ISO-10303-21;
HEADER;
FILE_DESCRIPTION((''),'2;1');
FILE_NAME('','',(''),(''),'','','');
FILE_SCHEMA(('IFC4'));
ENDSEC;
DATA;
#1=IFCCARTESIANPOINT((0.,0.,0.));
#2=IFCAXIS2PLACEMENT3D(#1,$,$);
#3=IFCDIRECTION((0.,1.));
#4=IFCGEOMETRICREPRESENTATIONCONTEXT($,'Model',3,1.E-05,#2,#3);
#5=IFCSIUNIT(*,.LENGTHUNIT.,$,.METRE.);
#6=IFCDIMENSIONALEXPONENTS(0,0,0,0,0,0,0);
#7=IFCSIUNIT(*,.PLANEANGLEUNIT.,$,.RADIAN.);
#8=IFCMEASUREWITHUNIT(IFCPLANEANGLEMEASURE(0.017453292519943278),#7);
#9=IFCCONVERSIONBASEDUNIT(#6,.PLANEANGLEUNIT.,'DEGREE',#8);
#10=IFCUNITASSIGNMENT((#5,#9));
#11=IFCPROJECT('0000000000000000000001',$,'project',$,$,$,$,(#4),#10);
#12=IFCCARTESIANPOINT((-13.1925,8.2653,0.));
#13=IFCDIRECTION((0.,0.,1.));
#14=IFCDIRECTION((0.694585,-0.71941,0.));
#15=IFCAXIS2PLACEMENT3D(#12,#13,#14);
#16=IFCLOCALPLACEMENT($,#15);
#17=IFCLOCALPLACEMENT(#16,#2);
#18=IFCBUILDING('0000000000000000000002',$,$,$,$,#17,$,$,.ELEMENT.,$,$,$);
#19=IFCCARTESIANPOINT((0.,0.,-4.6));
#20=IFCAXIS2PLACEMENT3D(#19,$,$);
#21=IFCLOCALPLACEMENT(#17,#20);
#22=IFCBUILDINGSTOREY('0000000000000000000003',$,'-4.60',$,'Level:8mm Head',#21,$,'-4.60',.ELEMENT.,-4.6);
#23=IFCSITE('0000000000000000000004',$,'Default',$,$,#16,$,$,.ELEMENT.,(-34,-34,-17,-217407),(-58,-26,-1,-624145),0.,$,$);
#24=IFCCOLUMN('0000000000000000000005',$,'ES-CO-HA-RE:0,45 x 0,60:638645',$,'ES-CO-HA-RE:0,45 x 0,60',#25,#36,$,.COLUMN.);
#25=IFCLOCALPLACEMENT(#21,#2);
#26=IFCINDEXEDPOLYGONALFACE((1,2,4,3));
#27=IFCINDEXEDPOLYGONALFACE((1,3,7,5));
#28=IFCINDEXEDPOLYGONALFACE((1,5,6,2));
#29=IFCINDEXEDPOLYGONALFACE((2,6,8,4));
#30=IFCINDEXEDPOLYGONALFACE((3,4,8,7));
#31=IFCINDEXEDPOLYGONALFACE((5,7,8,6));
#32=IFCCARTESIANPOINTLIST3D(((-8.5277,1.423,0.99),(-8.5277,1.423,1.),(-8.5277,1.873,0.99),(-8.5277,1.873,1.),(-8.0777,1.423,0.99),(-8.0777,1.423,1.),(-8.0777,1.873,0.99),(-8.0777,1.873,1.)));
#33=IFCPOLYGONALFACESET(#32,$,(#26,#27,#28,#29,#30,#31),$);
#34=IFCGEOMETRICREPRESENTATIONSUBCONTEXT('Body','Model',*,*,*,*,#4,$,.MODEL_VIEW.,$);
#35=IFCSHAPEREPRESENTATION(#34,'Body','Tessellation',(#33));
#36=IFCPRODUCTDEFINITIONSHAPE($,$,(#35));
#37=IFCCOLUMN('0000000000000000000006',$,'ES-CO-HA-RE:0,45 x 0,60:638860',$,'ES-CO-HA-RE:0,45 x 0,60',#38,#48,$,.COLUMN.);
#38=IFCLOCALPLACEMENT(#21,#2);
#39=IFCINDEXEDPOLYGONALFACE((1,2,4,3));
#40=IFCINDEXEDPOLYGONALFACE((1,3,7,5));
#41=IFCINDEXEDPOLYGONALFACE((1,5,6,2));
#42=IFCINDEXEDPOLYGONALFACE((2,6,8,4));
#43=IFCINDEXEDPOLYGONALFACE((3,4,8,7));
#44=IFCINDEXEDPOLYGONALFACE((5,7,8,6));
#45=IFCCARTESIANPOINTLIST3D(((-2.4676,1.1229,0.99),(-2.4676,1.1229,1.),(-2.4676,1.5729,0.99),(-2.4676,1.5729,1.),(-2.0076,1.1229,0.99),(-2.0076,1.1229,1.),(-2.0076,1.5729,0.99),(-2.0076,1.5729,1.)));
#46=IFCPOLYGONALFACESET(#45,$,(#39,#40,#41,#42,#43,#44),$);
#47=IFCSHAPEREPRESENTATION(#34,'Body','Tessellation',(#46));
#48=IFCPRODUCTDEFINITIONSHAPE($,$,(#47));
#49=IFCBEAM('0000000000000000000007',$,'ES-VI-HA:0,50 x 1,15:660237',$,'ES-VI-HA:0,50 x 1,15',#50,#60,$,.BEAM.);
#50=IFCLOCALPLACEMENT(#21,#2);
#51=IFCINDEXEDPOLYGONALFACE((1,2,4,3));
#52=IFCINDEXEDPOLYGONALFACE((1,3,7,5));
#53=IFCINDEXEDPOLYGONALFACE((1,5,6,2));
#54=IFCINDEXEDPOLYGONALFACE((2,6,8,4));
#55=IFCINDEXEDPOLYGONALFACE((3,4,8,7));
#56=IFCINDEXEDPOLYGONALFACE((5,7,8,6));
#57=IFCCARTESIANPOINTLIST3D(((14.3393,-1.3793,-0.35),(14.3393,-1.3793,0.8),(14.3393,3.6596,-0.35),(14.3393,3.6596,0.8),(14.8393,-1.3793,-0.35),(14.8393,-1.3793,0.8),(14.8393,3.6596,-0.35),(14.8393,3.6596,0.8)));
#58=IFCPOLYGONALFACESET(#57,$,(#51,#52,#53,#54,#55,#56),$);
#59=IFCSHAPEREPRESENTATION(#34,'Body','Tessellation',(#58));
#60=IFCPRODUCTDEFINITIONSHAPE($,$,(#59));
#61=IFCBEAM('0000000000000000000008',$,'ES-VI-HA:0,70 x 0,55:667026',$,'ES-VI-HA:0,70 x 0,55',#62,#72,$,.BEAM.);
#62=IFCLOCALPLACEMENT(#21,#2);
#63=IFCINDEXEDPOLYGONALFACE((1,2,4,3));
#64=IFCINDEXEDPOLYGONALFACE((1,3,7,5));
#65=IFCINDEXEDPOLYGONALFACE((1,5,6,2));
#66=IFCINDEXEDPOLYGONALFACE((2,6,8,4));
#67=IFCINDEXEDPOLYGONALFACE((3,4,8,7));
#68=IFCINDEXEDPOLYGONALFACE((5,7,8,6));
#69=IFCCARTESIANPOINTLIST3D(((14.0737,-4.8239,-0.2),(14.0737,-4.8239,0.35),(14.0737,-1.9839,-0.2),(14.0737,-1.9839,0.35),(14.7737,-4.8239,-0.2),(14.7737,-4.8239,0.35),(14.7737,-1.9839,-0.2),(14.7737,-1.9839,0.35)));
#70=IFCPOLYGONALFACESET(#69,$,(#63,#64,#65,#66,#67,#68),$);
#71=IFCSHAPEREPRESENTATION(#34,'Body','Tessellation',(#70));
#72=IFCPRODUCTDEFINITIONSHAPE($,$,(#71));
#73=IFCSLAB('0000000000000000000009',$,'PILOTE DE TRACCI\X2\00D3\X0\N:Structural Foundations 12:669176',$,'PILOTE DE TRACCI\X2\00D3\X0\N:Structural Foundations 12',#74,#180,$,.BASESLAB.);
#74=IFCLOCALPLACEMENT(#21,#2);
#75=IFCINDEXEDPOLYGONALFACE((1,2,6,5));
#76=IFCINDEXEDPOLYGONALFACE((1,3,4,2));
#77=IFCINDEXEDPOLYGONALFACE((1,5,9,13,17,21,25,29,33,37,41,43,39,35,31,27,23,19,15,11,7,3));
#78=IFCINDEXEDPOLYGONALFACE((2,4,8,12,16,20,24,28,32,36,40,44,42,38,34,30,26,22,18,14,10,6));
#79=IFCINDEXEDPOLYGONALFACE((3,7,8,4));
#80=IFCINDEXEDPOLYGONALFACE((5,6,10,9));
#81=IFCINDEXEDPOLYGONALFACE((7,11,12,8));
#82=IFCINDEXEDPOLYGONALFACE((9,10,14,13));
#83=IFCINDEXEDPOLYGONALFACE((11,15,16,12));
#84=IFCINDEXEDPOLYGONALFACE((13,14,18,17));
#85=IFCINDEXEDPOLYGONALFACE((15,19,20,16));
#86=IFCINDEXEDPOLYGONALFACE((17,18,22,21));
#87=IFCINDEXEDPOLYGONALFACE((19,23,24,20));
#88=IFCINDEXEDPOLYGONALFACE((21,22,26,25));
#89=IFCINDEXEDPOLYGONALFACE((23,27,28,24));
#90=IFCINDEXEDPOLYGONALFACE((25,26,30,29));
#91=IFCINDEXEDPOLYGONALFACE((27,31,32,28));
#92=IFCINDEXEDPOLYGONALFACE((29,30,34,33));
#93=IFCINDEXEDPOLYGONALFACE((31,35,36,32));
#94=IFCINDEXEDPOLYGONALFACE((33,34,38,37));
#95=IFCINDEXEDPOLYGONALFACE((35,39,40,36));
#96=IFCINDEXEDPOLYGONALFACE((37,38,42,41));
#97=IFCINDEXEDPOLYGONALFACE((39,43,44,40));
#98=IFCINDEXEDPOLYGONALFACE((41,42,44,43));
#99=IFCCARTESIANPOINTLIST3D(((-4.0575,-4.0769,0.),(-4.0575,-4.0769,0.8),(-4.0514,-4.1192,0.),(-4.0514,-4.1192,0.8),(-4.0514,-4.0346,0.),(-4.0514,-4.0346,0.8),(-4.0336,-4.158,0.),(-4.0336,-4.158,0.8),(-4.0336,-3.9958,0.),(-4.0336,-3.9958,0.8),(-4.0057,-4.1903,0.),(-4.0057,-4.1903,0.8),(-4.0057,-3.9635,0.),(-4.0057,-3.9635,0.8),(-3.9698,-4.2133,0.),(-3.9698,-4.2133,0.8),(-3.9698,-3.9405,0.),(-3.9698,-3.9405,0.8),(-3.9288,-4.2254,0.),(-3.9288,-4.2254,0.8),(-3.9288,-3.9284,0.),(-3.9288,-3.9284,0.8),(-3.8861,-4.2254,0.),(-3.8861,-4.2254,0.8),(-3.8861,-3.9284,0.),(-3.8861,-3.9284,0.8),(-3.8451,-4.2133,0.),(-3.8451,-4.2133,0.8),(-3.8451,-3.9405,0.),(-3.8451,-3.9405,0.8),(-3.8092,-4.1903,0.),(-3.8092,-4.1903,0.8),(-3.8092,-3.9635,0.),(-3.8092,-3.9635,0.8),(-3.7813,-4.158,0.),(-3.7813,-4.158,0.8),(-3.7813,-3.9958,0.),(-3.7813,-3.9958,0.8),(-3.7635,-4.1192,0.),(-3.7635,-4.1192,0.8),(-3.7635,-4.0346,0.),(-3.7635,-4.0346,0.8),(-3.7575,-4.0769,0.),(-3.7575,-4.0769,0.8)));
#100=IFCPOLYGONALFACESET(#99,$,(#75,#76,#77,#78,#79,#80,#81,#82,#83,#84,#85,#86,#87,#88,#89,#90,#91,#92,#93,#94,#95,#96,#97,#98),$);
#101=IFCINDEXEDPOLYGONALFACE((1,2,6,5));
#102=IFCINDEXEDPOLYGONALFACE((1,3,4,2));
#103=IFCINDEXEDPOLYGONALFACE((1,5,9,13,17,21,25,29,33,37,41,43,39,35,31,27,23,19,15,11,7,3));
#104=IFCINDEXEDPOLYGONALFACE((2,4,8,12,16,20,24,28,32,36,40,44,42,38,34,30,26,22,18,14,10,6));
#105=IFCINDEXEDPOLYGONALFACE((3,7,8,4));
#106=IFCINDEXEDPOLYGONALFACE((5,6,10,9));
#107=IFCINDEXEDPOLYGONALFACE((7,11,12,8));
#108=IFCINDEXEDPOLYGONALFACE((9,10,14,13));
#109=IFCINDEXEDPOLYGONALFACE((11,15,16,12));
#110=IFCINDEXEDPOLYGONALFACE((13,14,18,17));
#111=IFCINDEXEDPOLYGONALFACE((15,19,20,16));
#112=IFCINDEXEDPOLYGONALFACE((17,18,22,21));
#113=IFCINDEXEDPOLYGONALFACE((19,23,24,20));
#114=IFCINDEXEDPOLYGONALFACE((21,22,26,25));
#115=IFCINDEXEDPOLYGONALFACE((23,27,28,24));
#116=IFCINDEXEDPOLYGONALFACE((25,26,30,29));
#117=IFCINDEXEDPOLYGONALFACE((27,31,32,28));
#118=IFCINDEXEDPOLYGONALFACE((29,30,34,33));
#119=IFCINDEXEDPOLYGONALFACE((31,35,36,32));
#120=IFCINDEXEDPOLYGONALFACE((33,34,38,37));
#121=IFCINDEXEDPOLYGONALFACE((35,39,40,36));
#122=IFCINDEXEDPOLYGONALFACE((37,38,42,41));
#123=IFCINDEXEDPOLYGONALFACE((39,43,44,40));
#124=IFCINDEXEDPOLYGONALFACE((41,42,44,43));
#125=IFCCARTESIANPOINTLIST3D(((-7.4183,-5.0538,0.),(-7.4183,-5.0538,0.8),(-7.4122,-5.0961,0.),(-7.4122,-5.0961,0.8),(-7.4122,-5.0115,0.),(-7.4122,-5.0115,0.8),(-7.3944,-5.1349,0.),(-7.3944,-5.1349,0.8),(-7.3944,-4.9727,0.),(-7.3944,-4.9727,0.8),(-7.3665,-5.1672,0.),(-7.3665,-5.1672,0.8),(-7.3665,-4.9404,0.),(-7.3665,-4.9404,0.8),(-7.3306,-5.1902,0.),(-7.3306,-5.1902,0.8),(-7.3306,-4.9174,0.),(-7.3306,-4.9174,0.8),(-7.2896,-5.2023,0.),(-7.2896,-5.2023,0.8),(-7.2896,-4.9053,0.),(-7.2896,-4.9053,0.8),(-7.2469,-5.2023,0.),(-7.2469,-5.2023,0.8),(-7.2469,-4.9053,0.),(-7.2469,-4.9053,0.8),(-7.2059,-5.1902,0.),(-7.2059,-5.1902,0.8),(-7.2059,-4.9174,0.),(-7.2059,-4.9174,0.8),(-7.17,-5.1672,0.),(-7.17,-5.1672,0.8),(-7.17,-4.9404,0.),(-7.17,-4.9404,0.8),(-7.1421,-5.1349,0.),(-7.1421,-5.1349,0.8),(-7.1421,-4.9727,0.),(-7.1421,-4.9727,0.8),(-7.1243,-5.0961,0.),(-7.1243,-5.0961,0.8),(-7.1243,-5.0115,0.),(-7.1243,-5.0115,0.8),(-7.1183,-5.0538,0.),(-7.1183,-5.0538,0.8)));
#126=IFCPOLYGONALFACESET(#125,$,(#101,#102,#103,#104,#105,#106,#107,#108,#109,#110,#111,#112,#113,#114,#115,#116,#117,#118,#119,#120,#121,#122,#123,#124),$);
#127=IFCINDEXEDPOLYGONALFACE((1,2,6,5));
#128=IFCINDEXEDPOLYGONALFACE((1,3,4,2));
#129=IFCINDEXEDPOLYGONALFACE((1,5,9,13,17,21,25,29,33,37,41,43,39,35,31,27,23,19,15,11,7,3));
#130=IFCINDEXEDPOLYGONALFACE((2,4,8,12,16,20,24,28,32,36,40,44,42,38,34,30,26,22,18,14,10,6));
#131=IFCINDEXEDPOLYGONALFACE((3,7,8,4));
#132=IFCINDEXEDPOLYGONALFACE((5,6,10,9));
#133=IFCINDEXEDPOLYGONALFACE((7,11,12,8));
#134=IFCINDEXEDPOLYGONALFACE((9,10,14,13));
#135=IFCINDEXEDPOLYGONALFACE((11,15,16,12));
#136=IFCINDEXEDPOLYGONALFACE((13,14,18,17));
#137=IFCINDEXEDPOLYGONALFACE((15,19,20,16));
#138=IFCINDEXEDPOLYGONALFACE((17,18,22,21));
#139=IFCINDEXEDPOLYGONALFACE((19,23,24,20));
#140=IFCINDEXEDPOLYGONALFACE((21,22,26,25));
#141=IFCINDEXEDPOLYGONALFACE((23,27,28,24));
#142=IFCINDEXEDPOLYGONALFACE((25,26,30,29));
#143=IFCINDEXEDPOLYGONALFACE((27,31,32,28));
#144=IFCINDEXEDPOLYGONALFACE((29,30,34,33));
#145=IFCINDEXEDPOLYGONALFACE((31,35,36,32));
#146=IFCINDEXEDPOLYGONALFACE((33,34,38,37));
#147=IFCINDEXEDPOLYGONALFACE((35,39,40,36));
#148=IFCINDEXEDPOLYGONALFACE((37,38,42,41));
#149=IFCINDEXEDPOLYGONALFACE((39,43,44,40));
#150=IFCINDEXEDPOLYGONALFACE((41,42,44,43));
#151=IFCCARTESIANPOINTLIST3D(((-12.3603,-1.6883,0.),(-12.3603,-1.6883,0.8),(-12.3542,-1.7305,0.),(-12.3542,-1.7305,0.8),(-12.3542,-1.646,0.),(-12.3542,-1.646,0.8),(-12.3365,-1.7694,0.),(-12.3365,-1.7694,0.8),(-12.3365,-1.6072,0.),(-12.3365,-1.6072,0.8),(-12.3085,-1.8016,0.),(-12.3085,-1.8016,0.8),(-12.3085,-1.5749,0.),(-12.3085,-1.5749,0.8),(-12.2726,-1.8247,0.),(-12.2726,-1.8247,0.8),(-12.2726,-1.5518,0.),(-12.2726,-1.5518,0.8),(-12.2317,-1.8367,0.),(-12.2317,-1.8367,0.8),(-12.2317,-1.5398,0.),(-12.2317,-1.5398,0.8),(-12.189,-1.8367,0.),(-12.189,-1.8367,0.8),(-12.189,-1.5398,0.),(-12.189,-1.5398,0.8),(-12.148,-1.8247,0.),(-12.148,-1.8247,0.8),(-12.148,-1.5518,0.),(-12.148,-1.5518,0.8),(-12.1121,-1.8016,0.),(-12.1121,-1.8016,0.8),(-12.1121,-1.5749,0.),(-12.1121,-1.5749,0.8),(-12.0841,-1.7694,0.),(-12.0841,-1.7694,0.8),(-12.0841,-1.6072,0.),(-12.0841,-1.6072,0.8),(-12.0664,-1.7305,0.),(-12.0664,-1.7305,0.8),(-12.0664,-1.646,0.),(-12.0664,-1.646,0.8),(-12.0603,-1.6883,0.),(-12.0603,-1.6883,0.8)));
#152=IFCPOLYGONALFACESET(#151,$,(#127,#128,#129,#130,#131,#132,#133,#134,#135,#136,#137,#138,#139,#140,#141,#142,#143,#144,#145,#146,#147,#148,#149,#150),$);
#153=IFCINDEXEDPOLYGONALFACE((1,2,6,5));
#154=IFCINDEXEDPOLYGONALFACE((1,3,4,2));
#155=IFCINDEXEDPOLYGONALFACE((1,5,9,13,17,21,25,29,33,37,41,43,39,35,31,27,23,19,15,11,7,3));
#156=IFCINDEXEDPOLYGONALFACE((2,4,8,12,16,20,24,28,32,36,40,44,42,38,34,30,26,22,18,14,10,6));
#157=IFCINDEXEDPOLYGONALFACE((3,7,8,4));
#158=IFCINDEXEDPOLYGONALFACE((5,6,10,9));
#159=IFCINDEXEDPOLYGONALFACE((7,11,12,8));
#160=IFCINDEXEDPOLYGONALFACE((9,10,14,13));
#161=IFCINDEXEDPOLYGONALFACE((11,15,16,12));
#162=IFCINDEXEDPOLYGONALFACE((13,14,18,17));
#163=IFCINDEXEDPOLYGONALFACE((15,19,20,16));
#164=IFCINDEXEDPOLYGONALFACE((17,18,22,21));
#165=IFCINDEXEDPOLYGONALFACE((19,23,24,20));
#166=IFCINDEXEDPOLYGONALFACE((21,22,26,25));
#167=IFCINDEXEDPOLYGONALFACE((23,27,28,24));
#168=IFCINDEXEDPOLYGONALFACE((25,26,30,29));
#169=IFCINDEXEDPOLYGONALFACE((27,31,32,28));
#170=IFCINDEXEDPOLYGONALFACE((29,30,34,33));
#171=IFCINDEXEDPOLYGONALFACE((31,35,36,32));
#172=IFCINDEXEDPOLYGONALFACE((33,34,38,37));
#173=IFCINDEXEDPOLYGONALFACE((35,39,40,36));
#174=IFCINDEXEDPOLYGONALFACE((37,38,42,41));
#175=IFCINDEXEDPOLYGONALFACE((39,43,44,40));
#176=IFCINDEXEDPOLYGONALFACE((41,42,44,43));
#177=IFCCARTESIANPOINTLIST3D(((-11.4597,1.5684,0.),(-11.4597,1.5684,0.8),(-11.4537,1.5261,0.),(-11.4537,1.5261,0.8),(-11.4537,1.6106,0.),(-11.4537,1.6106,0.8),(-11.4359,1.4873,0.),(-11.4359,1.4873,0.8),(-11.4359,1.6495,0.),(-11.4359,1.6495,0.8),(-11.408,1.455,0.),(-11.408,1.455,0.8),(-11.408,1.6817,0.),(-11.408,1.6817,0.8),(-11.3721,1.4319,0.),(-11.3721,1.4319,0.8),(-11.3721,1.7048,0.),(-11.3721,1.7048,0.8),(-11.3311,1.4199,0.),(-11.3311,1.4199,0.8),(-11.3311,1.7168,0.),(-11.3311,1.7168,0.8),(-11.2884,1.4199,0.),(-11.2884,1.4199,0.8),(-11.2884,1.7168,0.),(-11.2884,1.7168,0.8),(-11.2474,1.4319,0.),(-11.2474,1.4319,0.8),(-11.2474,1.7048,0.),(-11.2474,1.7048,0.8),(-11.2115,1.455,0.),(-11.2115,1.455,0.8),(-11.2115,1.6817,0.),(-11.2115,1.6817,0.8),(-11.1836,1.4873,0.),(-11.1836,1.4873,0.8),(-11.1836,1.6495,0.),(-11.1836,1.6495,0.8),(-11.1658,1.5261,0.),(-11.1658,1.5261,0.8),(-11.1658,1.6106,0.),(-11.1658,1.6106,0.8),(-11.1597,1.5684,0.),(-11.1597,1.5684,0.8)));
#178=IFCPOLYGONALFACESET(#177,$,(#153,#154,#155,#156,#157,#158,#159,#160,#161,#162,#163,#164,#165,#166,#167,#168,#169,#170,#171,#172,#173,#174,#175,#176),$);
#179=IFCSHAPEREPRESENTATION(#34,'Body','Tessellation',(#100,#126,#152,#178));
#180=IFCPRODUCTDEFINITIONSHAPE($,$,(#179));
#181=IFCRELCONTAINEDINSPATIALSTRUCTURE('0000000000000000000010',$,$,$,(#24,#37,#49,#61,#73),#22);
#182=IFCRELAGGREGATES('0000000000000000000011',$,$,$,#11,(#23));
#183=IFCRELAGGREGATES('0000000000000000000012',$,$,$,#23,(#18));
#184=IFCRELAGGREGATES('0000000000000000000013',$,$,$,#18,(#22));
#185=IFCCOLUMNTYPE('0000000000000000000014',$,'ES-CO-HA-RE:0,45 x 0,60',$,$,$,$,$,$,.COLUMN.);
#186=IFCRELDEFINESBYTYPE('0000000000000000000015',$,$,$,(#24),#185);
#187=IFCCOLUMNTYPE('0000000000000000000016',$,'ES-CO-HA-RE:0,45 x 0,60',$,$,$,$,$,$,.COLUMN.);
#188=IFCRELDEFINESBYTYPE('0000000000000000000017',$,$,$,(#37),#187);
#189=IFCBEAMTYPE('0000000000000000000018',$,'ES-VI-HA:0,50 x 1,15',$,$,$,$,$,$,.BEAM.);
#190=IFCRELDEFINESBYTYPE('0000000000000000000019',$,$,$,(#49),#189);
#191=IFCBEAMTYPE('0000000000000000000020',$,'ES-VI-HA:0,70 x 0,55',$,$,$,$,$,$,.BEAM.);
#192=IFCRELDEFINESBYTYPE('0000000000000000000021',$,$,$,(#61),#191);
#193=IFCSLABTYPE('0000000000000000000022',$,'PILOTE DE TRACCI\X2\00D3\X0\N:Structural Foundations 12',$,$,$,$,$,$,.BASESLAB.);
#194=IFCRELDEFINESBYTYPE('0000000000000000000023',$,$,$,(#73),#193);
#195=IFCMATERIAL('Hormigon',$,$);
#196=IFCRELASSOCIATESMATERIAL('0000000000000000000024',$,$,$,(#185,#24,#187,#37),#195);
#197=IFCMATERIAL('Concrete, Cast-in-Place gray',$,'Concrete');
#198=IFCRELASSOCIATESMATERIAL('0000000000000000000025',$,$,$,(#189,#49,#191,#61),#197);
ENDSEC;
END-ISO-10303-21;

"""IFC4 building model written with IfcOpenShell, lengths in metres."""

from ifc_helpers import new_model, entity, si_unit, converted_unit, direction, frame, origin, place, context, subcontext, project, spatial, arc, indexed_curve, outline, extrude, source, transform, mapped, material, type_object, type_shapes, element, save


model = new_model("IFC4")

# Units and contexts
model_context = context("Model", 3, precision=1e-05, world=origin(), true_north=direction((0.0, 1.0)))
body_context = subcontext(model_context, "Body", "Model", "MODEL_VIEW")
ifc_project = project(units=[si_unit("LENGTHUNIT", "METRE"), converted_unit("PLANEANGLEUNIT", "DEGREE", entity("IfcPlaneAngleMeasure", 0.017453292519943278), si_unit("PLANEANGLEUNIT", "RADIAN"), dimensions=[0, 0, 0, 0, 0, 0, 0])], contexts=[model_context])

# Site, building, storey
site_placement = place(None, frame((-13.1925, 8.2653, 0.0), z_axis=(0.0, 0.0, 1.0), x_axis=(0.694585, -0.71941, 0.0)))
site = spatial("IfcSite", under=ifc_project, at=site_placement, Name="Default", CompositionType="ELEMENT", RefLatitude=(-34, -34, -17, -217407), RefLongitude=(-58, -26, -1, -624145), RefElevation=0.0)
building_placement = place(site_placement, origin())
building = spatial("IfcBuilding", under=site, at=building_placement, CompositionType="ELEMENT")
storey_placement = place(building_placement, frame((0.0, 0.0, -4.6)))
storey = spatial("IfcBuildingStorey", under=building, at=storey_placement, Name="-4.60", ObjectType="Level:8mm Head", LongName="-4.60", CompositionType="ELEMENT", Elevation=-4.6)

# Columns
ifc_material_1 = material(Name="Hormigon")
column_type_1 = type_object("IfcColumnType", Name="ES-CO-HA-RE:0,45 x 0,60", PredefinedType="COLUMN", material=ifc_material_1)
shared_shape_1 = source(origin(), body_context, "Body", "SweptSolid", [
    extrude(outline(indexed_curve([(-0.225, -0.225), (0.225, -0.225), (0.225, 0.225), (-0.225, 0.225), (-0.225, -0.225)], self_intersect=False)), frame((0.0, 0.0, -3.61), z_axis=(0.0, 0.0, 1.0), x_axis=(-1.0, 0.0, 0.0)), (0.0, 0.0, 1.0), 0.01),
])
type_shapes(column_type_1, [shared_shape_1])
column_1_placement = place(storey_placement, frame((-8.3027, 1.648, 4.6)))
element("IfcColumn", 1, at=column_1_placement, inside=storey, type_object=column_type_1, material=ifc_material_1, Name="ES-CO-HA-RE:0,45 x 0,60:638645", ObjectType="ES-CO-HA-RE:0,45 x 0,60", PredefinedType="COLUMN", context=body_context, shape_type="MappedRepresentation", body=[
    mapped(shared_shape_1, transform((0.0, 0.0, 0.0), scale=1.0)),
])
column_type_2 = type_object("IfcColumnType", Name="ES-CO-HA-RE:0,45 x 0,60", PredefinedType="COLUMN", material=ifc_material_1)
shared_shape_2 = source(origin(), body_context, "Body", "SweptSolid", [
    extrude(outline(indexed_curve([(-0.23, -0.225), (0.23, -0.225), (0.23, 0.225), (-0.23, 0.225), (-0.23, -0.225)], self_intersect=False)), frame((0.0, 0.0, -3.61), z_axis=(0.0, 0.0, 1.0), x_axis=(-1.0, 0.0, 0.0)), (0.0, 0.0, 1.0), 0.01),
])
type_shapes(column_type_2, [shared_shape_2])
column_2_placement = place(storey_placement, frame((-2.2376, 1.3479, 4.6)))
element("IfcColumn", 2, at=column_2_placement, inside=storey, type_object=column_type_2, material=ifc_material_1, Name="ES-CO-HA-RE:0,45 x 0,60:638860", ObjectType="ES-CO-HA-RE:0,45 x 0,60", PredefinedType="COLUMN", context=body_context, shape_type="MappedRepresentation", body=[
    mapped(shared_shape_2, transform((0.0, 0.0, 0.0), scale=1.0)),
])

# Beams
ifc_material_2 = material(Name="Concrete, Cast-in-Place gray", Category="Concrete")
beam_type_1 = type_object("IfcBeamType", Name="ES-VI-HA:0,50 x 1,15", PredefinedType="BEAM", material=ifc_material_2)
shared_shape_3 = source(origin(), body_context, "Body", "SweptSolid", [
    extrude(outline(indexed_curve([(-0.25, -0.575), (0.25, -0.575), (0.25, 0.575), (-0.25, 0.575), (-0.25, -0.575)], self_intersect=False)), frame((14.5893, -1.3793, -4.375), z_axis=(0.0, 1.0, 0.0), x_axis=(-1.0, 0.0, 0.0)), (0.0, 0.0, 1.0), 5.039),
])
type_shapes(beam_type_1, [shared_shape_3])
beam_1_placement = place(storey_placement, frame((0.0, 0.0, 4.6)))
element("IfcBeam", 3, at=beam_1_placement, inside=storey, type_object=beam_type_1, material=ifc_material_2, Name="ES-VI-HA:0,50 x 1,15:660237", ObjectType="ES-VI-HA:0,50 x 1,15", PredefinedType="BEAM", context=body_context, shape_type="MappedRepresentation", body=[
    mapped(shared_shape_3, transform((0.0, 0.0, 0.0), scale=1.0)),
])
beam_type_2 = type_object("IfcBeamType", Name="ES-VI-HA:0,70 x 0,55", PredefinedType="BEAM", material=ifc_material_2)
shared_shape_4 = source(origin(), body_context, "Body", "SweptSolid", [
    extrude(outline(indexed_curve([(-0.35, -0.275), (0.35, -0.275), (0.35, 0.275), (-0.35, 0.275), (-0.35, -0.275)], self_intersect=False)), frame((14.4237, -1.9839, -4.525), z_axis=(0.0, -1.0, 0.0), x_axis=(-1.0, 0.0, 0.0)), (0.0, 0.0, 1.0), 2.84),
])
type_shapes(beam_type_2, [shared_shape_4])
beam_2_placement = place(storey_placement, frame((0.0, 0.0, 4.6)))
element("IfcBeam", 4, at=beam_2_placement, inside=storey, type_object=beam_type_2, material=ifc_material_2, Name="ES-VI-HA:0,70 x 0,55:667026", ObjectType="ES-VI-HA:0,70 x 0,55", PredefinedType="BEAM", context=body_context, shape_type="MappedRepresentation", body=[
    mapped(shared_shape_4, transform((0.0, 0.0, 0.0), scale=1.0)),
])

# Slab
slab_type_1 = type_object("IfcSlabType", Name="PILOTE DE TRACCIÓN:Structural Foundations 12", PredefinedType="BASESLAB")
slab_1_placement = place(storey_placement, origin())
element("IfcSlab", 5, at=slab_1_placement, inside=storey, type_object=slab_type_1, Name="PILOTE DE TRACCIÓN:Structural Foundations 12:669176", ObjectType="PILOTE DE TRACCIÓN:Structural Foundations 12", PredefinedType="BASESLAB", context=body_context, shape_type="SweptSolid", body=[
    extrude(outline(indexed_curve([(-0.15, 0.0), (0.0, -0.15), (0.15, 0.0), (0.0, 0.15)], segments=[arc(1, 2, 3), arc(3, 4, 1)], self_intersect=False)), frame((-3.9075, -4.0769, 0.0)), (0.0, 0.0, 1.0), 0.8),
    extrude(outline(indexed_curve([(-0.15, 0.0), (0.0, -0.15), (0.15, 0.0), (0.0, 0.15)], segments=[arc(1, 2, 3), arc(3, 4, 1)], self_intersect=False)), frame((-7.2683, -5.0538, 0.0)), (0.0, 0.0, 1.0), 0.8),
    extrude(outline(indexed_curve([(-0.15, 0.0), (0.0, -0.15), (0.15, 0.0), (0.0, 0.15)], segments=[arc(1, 2, 3), arc(3, 4, 1)], self_intersect=False)), frame((-12.2103, -1.6883, 0.0)), (0.0, 0.0, 1.0), 0.8),
    extrude(outline(indexed_curve([(-0.15, 0.0), (0.0, -0.15), (0.15, 0.0), (0.0, 0.15)], segments=[arc(1, 2, 3), arc(3, 4, 1)], self_intersect=False)), frame((-11.3097, 1.5684, 0.0)), (0.0, 0.0, 1.0), 0.8),
])

save(model, "model.ifc")
